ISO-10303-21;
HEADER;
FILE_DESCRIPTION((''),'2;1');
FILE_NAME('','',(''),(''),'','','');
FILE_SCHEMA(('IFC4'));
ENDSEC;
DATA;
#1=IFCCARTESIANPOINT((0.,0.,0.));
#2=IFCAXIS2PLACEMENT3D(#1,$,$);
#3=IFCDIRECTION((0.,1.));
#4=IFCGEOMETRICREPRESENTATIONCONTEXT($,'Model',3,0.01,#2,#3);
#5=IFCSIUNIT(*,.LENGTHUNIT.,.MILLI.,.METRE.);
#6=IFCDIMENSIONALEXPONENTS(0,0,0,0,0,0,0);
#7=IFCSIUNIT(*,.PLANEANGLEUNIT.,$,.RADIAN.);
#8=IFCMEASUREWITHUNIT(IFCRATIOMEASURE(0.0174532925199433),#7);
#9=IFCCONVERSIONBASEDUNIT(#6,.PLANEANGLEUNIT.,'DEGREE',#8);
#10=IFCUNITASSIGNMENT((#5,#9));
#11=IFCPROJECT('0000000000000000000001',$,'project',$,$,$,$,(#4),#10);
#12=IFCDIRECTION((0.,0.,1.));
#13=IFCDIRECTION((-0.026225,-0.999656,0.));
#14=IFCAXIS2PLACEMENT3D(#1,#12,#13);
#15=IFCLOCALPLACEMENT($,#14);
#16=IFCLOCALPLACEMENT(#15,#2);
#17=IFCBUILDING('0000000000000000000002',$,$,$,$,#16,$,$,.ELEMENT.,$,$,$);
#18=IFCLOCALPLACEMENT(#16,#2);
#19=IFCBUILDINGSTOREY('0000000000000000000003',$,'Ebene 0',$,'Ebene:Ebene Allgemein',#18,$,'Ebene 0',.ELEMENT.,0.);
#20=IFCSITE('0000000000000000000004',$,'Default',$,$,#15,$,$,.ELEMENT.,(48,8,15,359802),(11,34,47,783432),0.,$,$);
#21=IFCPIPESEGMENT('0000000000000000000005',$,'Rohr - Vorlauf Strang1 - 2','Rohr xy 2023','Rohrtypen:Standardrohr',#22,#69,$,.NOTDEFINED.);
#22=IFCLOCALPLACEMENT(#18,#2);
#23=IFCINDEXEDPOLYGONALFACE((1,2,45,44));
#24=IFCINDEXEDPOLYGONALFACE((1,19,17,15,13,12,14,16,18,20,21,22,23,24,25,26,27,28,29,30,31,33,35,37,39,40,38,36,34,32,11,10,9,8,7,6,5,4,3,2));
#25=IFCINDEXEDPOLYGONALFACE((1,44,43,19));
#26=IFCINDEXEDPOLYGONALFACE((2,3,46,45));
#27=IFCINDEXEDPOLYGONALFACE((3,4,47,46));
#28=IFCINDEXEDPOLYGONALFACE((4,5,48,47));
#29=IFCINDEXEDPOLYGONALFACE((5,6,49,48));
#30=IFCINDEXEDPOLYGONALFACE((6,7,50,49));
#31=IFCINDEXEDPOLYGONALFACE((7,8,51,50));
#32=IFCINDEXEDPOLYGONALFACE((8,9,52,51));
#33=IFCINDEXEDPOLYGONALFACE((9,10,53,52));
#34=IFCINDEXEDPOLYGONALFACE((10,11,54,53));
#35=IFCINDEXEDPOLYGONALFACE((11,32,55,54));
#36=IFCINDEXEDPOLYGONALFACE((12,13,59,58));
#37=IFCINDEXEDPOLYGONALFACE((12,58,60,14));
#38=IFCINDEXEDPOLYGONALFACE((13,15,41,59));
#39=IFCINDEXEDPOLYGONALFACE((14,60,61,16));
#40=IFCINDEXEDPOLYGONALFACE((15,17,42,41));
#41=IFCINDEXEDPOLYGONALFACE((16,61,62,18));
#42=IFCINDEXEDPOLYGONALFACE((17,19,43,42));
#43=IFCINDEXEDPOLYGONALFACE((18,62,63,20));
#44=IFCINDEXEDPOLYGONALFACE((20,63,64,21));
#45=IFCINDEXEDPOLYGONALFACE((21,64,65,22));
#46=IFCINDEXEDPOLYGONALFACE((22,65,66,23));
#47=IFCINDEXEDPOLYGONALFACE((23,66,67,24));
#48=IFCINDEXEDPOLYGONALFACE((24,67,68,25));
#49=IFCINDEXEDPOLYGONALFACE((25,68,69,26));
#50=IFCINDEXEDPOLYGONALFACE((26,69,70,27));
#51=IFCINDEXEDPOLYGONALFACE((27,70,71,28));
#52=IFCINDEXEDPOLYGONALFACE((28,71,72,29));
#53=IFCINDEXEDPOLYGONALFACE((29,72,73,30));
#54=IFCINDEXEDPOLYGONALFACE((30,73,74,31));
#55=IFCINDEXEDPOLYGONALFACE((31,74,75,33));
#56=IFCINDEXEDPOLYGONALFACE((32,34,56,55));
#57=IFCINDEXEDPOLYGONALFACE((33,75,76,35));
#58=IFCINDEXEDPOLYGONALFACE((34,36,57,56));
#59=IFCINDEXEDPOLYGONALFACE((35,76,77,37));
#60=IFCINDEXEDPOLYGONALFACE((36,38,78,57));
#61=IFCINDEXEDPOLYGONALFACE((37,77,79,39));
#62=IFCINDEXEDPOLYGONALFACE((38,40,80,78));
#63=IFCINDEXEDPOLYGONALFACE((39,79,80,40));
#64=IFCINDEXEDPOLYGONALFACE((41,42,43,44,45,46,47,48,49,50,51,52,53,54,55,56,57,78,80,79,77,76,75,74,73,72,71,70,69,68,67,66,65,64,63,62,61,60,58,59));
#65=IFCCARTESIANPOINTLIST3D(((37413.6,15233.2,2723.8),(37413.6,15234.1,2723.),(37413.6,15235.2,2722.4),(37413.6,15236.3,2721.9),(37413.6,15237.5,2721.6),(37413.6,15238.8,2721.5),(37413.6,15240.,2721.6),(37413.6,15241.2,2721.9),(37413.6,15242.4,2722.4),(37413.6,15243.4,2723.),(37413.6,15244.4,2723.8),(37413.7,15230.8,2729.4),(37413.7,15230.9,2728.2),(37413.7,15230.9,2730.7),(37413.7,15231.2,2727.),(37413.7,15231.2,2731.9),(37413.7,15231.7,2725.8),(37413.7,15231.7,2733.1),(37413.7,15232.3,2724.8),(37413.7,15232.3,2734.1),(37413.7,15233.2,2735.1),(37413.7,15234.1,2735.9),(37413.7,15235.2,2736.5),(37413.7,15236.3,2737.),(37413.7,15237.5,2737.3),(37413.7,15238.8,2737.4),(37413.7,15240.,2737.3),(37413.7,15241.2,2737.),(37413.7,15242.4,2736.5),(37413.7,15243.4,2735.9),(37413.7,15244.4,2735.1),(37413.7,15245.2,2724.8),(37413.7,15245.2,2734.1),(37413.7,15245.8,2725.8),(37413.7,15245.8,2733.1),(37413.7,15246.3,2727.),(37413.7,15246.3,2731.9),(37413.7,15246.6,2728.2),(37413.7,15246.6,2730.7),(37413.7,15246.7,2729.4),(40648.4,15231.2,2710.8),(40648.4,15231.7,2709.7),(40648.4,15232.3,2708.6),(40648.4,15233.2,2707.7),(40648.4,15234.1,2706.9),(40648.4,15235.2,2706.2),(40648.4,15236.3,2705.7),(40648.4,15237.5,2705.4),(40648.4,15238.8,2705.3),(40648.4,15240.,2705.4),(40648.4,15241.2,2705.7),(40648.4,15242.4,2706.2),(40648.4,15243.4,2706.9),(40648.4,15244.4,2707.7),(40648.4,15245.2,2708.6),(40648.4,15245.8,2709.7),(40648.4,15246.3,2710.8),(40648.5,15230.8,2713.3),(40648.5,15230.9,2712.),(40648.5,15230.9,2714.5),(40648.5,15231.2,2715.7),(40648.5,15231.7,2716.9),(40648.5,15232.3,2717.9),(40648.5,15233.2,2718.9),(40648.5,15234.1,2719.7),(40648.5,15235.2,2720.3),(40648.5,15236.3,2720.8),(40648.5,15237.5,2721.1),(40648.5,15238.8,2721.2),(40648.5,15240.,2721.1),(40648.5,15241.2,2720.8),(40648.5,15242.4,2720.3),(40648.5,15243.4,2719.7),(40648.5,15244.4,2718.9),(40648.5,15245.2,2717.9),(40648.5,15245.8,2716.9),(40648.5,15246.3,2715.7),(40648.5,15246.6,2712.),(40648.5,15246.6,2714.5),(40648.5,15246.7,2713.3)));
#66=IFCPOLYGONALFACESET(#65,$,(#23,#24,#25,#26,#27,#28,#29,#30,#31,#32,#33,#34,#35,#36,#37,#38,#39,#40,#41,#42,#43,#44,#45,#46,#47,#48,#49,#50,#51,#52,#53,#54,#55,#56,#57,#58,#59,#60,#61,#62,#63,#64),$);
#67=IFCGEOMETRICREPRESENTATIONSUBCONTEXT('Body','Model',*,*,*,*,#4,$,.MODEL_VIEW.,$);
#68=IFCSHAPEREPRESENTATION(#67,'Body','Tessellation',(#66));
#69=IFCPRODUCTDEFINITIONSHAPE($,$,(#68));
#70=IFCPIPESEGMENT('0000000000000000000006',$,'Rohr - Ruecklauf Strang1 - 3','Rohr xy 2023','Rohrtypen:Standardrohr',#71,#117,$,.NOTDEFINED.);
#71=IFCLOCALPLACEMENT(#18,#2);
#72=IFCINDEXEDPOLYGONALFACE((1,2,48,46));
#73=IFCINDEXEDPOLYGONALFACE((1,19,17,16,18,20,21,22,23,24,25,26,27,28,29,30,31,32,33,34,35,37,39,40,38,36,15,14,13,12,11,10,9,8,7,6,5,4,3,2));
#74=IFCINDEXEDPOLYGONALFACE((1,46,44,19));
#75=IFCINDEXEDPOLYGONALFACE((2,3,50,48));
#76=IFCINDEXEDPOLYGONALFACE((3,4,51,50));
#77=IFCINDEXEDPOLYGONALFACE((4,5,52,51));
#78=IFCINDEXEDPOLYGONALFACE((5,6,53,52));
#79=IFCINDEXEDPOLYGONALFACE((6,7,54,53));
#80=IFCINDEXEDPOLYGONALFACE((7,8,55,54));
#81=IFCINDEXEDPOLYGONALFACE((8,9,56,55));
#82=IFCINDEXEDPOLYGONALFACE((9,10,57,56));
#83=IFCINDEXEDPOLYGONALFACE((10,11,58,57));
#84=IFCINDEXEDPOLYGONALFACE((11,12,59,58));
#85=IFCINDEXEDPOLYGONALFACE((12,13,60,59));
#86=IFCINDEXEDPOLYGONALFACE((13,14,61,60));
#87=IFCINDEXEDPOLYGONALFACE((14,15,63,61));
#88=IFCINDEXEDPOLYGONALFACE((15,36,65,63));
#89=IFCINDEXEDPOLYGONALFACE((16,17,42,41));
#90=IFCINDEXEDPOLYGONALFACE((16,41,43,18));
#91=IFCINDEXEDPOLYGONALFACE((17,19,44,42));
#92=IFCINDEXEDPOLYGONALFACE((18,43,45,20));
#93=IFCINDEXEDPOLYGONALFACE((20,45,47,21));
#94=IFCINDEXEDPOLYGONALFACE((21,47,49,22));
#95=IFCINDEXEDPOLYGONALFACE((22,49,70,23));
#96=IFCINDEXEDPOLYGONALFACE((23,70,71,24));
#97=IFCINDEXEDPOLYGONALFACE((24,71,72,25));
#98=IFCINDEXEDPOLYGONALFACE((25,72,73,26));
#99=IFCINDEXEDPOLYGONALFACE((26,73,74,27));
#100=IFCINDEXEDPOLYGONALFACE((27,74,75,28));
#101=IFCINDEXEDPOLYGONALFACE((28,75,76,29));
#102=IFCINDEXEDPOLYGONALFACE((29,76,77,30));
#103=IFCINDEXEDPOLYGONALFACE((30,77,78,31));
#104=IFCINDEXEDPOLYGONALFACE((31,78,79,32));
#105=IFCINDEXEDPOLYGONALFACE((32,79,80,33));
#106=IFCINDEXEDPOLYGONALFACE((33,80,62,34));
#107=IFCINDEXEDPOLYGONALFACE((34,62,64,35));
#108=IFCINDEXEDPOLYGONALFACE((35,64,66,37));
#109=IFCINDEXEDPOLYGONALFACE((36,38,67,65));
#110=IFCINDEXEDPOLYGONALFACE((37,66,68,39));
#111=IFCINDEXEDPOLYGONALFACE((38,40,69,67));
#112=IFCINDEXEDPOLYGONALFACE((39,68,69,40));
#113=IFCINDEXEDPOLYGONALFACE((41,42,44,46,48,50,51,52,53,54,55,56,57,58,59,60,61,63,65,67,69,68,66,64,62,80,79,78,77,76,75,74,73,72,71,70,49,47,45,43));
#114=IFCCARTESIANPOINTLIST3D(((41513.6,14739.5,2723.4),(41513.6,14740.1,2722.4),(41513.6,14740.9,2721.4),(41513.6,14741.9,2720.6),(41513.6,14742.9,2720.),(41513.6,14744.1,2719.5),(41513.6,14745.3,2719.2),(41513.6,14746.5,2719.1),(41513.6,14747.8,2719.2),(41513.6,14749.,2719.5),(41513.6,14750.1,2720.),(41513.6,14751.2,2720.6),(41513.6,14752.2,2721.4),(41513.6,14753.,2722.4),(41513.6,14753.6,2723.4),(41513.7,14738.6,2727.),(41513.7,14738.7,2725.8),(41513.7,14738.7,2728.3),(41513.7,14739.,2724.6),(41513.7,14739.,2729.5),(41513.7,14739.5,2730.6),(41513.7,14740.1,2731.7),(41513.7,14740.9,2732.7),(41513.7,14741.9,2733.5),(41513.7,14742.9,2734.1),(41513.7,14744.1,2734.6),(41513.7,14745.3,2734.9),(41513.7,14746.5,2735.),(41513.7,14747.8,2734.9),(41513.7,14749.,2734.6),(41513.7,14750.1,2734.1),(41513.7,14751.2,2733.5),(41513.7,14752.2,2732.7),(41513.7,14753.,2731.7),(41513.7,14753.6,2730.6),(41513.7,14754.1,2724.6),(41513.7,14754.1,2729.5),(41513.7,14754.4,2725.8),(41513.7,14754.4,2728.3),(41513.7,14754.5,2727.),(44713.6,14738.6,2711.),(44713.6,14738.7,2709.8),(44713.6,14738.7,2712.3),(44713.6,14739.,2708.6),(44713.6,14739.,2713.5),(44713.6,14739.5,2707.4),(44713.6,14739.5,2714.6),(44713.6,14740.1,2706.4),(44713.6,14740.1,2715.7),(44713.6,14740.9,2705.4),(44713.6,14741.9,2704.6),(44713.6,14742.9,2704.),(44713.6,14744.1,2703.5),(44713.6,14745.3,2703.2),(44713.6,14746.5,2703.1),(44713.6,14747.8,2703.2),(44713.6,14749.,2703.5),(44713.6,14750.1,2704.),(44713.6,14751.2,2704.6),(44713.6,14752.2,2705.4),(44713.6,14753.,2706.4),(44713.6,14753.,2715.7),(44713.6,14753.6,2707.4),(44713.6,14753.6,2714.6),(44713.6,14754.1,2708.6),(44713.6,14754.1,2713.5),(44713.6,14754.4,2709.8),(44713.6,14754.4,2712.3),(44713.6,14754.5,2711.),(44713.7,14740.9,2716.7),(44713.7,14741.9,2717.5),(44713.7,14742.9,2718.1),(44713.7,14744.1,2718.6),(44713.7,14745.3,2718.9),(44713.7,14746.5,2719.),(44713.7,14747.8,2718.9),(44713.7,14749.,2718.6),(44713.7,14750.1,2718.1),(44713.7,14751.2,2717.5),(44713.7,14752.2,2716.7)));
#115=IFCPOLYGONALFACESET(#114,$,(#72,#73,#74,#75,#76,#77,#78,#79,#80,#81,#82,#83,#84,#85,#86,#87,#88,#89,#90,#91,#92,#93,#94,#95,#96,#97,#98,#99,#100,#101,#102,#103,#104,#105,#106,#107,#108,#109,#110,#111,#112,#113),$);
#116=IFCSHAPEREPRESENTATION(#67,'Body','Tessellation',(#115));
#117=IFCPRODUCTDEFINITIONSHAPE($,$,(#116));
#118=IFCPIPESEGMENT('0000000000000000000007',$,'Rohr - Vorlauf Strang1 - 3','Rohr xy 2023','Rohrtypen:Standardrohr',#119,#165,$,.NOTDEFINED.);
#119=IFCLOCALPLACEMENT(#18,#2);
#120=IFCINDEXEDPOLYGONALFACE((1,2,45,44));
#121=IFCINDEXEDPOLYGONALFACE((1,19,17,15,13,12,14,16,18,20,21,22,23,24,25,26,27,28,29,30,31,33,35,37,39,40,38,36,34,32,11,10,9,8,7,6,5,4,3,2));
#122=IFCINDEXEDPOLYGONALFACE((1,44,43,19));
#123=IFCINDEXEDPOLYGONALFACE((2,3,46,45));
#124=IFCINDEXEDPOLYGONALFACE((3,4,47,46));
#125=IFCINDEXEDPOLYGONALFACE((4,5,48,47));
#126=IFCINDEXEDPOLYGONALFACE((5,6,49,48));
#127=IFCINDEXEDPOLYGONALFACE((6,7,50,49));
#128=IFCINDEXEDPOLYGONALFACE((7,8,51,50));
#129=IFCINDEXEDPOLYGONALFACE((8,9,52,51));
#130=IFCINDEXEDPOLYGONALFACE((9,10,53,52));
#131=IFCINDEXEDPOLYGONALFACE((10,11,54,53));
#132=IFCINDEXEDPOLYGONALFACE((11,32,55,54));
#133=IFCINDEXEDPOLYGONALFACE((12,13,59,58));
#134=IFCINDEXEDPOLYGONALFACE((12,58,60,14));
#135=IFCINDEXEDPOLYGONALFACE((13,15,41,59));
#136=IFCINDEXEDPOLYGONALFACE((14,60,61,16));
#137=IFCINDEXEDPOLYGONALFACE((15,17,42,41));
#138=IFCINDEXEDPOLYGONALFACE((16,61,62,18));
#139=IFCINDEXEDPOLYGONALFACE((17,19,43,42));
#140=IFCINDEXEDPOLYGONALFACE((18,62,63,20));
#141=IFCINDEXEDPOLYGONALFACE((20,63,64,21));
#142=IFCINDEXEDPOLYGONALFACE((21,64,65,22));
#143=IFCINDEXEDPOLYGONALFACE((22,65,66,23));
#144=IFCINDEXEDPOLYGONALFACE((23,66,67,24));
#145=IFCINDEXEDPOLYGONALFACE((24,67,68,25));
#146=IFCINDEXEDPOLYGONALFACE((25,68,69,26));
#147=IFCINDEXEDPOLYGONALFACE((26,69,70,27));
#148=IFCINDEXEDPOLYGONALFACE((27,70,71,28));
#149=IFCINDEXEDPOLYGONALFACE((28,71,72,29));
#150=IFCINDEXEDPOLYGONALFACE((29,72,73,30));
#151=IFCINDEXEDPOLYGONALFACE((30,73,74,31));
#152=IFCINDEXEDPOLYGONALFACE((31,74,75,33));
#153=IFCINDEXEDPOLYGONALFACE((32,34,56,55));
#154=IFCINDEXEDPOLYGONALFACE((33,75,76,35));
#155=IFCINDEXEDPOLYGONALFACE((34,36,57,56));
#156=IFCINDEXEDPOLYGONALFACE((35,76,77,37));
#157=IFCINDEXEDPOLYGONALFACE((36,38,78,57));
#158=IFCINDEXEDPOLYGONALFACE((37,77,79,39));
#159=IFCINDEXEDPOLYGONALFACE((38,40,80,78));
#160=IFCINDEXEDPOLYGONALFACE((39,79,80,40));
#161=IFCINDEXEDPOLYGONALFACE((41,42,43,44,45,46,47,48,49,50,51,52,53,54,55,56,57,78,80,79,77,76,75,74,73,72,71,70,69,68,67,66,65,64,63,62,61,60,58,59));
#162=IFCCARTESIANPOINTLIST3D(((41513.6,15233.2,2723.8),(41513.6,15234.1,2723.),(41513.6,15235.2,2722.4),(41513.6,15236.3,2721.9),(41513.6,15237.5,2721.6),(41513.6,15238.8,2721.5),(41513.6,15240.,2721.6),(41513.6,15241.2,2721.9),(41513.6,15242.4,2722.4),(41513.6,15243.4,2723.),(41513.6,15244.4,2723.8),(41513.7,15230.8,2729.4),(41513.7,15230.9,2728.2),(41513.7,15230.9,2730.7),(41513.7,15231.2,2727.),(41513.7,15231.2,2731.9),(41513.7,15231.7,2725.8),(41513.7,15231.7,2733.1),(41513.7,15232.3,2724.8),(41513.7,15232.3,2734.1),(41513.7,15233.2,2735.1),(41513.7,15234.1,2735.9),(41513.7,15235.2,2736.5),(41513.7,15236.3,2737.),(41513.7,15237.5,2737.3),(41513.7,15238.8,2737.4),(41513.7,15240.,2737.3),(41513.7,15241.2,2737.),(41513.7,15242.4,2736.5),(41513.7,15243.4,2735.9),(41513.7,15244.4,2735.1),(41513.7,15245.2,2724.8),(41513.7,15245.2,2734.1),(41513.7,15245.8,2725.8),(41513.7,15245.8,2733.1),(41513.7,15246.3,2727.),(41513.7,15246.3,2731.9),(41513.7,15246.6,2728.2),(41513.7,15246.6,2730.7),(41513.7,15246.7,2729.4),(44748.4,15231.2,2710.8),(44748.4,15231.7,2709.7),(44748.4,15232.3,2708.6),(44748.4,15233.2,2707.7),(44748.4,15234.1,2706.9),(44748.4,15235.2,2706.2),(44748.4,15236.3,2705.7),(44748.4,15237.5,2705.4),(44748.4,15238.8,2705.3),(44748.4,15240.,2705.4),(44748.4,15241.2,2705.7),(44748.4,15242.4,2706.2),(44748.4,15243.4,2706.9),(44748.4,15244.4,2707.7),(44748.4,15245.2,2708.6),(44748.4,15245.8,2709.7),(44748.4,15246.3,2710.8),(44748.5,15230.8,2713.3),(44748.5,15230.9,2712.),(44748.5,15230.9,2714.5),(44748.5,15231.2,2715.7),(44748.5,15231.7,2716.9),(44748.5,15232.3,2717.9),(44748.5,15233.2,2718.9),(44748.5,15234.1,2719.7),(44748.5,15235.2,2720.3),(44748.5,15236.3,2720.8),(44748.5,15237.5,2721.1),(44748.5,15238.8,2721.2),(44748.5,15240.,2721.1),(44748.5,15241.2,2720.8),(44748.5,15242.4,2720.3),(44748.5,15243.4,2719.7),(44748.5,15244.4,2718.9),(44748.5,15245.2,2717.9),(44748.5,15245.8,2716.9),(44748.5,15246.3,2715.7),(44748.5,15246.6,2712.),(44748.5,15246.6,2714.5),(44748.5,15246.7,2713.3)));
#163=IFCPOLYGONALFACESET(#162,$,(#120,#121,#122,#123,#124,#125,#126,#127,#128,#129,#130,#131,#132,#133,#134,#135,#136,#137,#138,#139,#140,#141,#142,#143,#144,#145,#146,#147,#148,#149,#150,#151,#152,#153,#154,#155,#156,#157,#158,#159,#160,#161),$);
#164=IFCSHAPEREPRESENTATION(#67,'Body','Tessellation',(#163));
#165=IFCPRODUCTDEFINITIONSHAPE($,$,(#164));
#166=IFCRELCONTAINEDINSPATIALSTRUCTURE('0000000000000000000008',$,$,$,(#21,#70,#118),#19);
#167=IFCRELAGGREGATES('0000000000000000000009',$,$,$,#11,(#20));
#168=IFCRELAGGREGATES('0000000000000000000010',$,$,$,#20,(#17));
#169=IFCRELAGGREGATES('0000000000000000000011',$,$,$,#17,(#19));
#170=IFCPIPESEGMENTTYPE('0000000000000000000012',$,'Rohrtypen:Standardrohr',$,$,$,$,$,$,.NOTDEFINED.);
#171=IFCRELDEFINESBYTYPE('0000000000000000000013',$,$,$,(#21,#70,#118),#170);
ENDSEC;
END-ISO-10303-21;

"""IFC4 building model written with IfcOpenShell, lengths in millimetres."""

from ifc_helpers import new_model, entity, si_unit, converted_unit, direction, frame, origin, place, context, subcontext, project, spatial, indexed_curve, outline, extrude, type_object, element, save


model = new_model("IFC4")

# Units and contexts
model_context = context("Model", 3, precision=0.01, world=origin(), true_north=direction((0.0, 1.0)))
body_context = subcontext(model_context, "Body", "Model", "MODEL_VIEW")
ifc_project = project(units=[si_unit("LENGTHUNIT", "METRE", prefix="MILLI"), converted_unit("PLANEANGLEUNIT", "DEGREE", entity("IfcRatioMeasure", 0.0174532925199433), si_unit("PLANEANGLEUNIT", "RADIAN"), dimensions=[0, 0, 0, 0, 0, 0, 0])], contexts=[model_context])

# Site, building, storey
site_placement = place(None, frame((0.0, 0.0, 0.0), z_axis=(0.0, 0.0, 1.0), x_axis=(-0.026225, -0.999656, 0.0)))
site = spatial("IfcSite", under=ifc_project, at=site_placement, Name="Default", CompositionType="ELEMENT", RefLatitude=(48, 8, 15, 359802), RefLongitude=(11, 34, 47, 783432), RefElevation=0.0)
building_placement = place(site_placement, origin())
building = spatial("IfcBuilding", under=site, at=building_placement, CompositionType="ELEMENT")
storey_placement = place(building_placement, origin())
storey = spatial("IfcBuildingStorey", under=building, at=storey_placement, Name="Ebene 0", ObjectType="Ebene:Ebene Allgemein", LongName="Ebene 0", CompositionType="ELEMENT", Elevation=0.0)

# Pipe segments
pipe_segment_type = type_object("IfcPipeSegmentType", Name="Rohrtypen:Standardrohr", PredefinedType="NOTDEFINED")
pipe_segment_1_placement = place(storey_placement, origin())
element("IfcPipeSegment", 1, at=pipe_segment_1_placement, inside=storey, type_object=pipe_segment_type, Name="Rohr - Vorlauf Strang1 - 2", Description="Rohr xy 2023", ObjectType="Rohrtypen:Standardrohr", PredefinedType="NOTDEFINED", context=body_context, shape_type="SweptSolid", body=[
    extrude(outline(indexed_curve([(7.9, 0.0), (7.8, 1.2), (7.6, 2.5), (7.1, 3.6), (6.4, 4.7), (5.6, 5.6), (4.7, 6.4), (3.6, 7.1), (2.5, 7.6), (1.2, 7.8), (0.0, 7.9), (-1.2, 7.8), (-2.5, 7.6), (-3.6, 7.1), (-4.7, 6.4), (-5.6, 5.6), (-6.4, 4.7), (-7.1, 3.6), (-7.6, 2.5), (-7.8, 1.2), (-7.9, 0.0), (-7.8, -1.2), (-7.6, -2.5), (-7.1, -3.6), (-6.4, -4.7), (-5.6, -5.6), (-4.7, -6.4), (-3.6, -7.1), (-2.5, -7.6), (-1.2, -7.8), (0.0, -7.9), (1.2, -7.8), (2.5, -7.6), (3.6, -7.1), (4.7, -6.4), (5.6, -5.6), (6.4, -4.7), (7.1, -3.6), (7.6, -2.5), (7.8, -1.2), (7.9, 0.0)], self_intersect=False)), frame((40648.5, 15238.8, 2713.3), z_axis=(-0.999988, 0.0, 0.005), x_axis=(0.0, 1.0, 0.0)), (0.0, 0.0, 1.0), 3234.8),
])
pipe_segment_2_placement = place(storey_placement, origin())
element("IfcPipeSegment", 2, at=pipe_segment_2_placement, inside=storey, type_object=pipe_segment_type, Name="Rohr - Ruecklauf Strang1 - 3", Description="Rohr xy 2023", ObjectType="Rohrtypen:Standardrohr", PredefinedType="NOTDEFINED", context=body_context, shape_type="SweptSolid", body=[
    extrude(outline(indexed_curve([(7.9, 0.0), (7.8, 1.2), (7.6, 2.5), (7.1, 3.6), (6.4, 4.7), (5.6, 5.6), (4.7, 6.4), (3.6, 7.1), (2.5, 7.6), (1.2, 7.8), (0.0, 7.9), (-1.2, 7.8), (-2.5, 7.6), (-3.6, 7.1), (-4.7, 6.4), (-5.6, 5.6), (-6.4, 4.7), (-7.1, 3.6), (-7.6, 2.5), (-7.8, 1.2), (-7.9, 0.0), (-7.8, -1.2), (-7.6, -2.5), (-7.1, -3.6), (-6.4, -4.7), (-5.6, -5.6), (-4.7, -6.4), (-3.6, -7.1), (-2.5, -7.6), (-1.2, -7.8), (0.0, -7.9), (1.2, -7.8), (2.5, -7.6), (3.6, -7.1), (4.7, -6.4), (5.6, -5.6), (6.4, -4.7), (7.1, -3.6), (7.6, -2.5), (7.8, -1.2), (7.9, 0.0)], self_intersect=False)), frame((44713.6, 14746.5, 2711.0), z_axis=(-0.999988, 0.0, 0.005), x_axis=(0.0, 1.0, 0.0)), (0.0, 0.0, 1.0), 3200.0),
])
pipe_segment_3_placement = place(storey_placement, origin())
element("IfcPipeSegment", 3, at=pipe_segment_3_placement, inside=storey, type_object=pipe_segment_type, Name="Rohr - Vorlauf Strang1 - 3", Description="Rohr xy 2023", ObjectType="Rohrtypen:Standardrohr", PredefinedType="NOTDEFINED", context=body_context, shape_type="SweptSolid", body=[
    extrude(outline(indexed_curve([(7.9, 0.0), (7.8, 1.2), (7.6, 2.5), (7.1, 3.6), (6.4, 4.7), (5.6, 5.6), (4.7, 6.4), (3.6, 7.1), (2.5, 7.6), (1.2, 7.8), (0.0, 7.9), (-1.2, 7.8), (-2.5, 7.6), (-3.6, 7.1), (-4.7, 6.4), (-5.6, 5.6), (-6.4, 4.7), (-7.1, 3.6), (-7.6, 2.5), (-7.8, 1.2), (-7.9, 0.0), (-7.8, -1.2), (-7.6, -2.5), (-7.1, -3.6), (-6.4, -4.7), (-5.6, -5.6), (-4.7, -6.4), (-3.6, -7.1), (-2.5, -7.6), (-1.2, -7.8), (0.0, -7.9), (1.2, -7.8), (2.5, -7.6), (3.6, -7.1), (4.7, -6.4), (5.6, -5.6), (6.4, -4.7), (7.1, -3.6), (7.6, -2.5), (7.8, -1.2), (7.9, 0.0)], self_intersect=False)), frame((44748.5, 15238.8, 2713.3), z_axis=(-0.999988, 0.0, 0.005), x_axis=(0.0, 1.0, 0.0)), (0.0, 0.0, 1.0), 3234.8),
])

save(model, "model.ifc")
